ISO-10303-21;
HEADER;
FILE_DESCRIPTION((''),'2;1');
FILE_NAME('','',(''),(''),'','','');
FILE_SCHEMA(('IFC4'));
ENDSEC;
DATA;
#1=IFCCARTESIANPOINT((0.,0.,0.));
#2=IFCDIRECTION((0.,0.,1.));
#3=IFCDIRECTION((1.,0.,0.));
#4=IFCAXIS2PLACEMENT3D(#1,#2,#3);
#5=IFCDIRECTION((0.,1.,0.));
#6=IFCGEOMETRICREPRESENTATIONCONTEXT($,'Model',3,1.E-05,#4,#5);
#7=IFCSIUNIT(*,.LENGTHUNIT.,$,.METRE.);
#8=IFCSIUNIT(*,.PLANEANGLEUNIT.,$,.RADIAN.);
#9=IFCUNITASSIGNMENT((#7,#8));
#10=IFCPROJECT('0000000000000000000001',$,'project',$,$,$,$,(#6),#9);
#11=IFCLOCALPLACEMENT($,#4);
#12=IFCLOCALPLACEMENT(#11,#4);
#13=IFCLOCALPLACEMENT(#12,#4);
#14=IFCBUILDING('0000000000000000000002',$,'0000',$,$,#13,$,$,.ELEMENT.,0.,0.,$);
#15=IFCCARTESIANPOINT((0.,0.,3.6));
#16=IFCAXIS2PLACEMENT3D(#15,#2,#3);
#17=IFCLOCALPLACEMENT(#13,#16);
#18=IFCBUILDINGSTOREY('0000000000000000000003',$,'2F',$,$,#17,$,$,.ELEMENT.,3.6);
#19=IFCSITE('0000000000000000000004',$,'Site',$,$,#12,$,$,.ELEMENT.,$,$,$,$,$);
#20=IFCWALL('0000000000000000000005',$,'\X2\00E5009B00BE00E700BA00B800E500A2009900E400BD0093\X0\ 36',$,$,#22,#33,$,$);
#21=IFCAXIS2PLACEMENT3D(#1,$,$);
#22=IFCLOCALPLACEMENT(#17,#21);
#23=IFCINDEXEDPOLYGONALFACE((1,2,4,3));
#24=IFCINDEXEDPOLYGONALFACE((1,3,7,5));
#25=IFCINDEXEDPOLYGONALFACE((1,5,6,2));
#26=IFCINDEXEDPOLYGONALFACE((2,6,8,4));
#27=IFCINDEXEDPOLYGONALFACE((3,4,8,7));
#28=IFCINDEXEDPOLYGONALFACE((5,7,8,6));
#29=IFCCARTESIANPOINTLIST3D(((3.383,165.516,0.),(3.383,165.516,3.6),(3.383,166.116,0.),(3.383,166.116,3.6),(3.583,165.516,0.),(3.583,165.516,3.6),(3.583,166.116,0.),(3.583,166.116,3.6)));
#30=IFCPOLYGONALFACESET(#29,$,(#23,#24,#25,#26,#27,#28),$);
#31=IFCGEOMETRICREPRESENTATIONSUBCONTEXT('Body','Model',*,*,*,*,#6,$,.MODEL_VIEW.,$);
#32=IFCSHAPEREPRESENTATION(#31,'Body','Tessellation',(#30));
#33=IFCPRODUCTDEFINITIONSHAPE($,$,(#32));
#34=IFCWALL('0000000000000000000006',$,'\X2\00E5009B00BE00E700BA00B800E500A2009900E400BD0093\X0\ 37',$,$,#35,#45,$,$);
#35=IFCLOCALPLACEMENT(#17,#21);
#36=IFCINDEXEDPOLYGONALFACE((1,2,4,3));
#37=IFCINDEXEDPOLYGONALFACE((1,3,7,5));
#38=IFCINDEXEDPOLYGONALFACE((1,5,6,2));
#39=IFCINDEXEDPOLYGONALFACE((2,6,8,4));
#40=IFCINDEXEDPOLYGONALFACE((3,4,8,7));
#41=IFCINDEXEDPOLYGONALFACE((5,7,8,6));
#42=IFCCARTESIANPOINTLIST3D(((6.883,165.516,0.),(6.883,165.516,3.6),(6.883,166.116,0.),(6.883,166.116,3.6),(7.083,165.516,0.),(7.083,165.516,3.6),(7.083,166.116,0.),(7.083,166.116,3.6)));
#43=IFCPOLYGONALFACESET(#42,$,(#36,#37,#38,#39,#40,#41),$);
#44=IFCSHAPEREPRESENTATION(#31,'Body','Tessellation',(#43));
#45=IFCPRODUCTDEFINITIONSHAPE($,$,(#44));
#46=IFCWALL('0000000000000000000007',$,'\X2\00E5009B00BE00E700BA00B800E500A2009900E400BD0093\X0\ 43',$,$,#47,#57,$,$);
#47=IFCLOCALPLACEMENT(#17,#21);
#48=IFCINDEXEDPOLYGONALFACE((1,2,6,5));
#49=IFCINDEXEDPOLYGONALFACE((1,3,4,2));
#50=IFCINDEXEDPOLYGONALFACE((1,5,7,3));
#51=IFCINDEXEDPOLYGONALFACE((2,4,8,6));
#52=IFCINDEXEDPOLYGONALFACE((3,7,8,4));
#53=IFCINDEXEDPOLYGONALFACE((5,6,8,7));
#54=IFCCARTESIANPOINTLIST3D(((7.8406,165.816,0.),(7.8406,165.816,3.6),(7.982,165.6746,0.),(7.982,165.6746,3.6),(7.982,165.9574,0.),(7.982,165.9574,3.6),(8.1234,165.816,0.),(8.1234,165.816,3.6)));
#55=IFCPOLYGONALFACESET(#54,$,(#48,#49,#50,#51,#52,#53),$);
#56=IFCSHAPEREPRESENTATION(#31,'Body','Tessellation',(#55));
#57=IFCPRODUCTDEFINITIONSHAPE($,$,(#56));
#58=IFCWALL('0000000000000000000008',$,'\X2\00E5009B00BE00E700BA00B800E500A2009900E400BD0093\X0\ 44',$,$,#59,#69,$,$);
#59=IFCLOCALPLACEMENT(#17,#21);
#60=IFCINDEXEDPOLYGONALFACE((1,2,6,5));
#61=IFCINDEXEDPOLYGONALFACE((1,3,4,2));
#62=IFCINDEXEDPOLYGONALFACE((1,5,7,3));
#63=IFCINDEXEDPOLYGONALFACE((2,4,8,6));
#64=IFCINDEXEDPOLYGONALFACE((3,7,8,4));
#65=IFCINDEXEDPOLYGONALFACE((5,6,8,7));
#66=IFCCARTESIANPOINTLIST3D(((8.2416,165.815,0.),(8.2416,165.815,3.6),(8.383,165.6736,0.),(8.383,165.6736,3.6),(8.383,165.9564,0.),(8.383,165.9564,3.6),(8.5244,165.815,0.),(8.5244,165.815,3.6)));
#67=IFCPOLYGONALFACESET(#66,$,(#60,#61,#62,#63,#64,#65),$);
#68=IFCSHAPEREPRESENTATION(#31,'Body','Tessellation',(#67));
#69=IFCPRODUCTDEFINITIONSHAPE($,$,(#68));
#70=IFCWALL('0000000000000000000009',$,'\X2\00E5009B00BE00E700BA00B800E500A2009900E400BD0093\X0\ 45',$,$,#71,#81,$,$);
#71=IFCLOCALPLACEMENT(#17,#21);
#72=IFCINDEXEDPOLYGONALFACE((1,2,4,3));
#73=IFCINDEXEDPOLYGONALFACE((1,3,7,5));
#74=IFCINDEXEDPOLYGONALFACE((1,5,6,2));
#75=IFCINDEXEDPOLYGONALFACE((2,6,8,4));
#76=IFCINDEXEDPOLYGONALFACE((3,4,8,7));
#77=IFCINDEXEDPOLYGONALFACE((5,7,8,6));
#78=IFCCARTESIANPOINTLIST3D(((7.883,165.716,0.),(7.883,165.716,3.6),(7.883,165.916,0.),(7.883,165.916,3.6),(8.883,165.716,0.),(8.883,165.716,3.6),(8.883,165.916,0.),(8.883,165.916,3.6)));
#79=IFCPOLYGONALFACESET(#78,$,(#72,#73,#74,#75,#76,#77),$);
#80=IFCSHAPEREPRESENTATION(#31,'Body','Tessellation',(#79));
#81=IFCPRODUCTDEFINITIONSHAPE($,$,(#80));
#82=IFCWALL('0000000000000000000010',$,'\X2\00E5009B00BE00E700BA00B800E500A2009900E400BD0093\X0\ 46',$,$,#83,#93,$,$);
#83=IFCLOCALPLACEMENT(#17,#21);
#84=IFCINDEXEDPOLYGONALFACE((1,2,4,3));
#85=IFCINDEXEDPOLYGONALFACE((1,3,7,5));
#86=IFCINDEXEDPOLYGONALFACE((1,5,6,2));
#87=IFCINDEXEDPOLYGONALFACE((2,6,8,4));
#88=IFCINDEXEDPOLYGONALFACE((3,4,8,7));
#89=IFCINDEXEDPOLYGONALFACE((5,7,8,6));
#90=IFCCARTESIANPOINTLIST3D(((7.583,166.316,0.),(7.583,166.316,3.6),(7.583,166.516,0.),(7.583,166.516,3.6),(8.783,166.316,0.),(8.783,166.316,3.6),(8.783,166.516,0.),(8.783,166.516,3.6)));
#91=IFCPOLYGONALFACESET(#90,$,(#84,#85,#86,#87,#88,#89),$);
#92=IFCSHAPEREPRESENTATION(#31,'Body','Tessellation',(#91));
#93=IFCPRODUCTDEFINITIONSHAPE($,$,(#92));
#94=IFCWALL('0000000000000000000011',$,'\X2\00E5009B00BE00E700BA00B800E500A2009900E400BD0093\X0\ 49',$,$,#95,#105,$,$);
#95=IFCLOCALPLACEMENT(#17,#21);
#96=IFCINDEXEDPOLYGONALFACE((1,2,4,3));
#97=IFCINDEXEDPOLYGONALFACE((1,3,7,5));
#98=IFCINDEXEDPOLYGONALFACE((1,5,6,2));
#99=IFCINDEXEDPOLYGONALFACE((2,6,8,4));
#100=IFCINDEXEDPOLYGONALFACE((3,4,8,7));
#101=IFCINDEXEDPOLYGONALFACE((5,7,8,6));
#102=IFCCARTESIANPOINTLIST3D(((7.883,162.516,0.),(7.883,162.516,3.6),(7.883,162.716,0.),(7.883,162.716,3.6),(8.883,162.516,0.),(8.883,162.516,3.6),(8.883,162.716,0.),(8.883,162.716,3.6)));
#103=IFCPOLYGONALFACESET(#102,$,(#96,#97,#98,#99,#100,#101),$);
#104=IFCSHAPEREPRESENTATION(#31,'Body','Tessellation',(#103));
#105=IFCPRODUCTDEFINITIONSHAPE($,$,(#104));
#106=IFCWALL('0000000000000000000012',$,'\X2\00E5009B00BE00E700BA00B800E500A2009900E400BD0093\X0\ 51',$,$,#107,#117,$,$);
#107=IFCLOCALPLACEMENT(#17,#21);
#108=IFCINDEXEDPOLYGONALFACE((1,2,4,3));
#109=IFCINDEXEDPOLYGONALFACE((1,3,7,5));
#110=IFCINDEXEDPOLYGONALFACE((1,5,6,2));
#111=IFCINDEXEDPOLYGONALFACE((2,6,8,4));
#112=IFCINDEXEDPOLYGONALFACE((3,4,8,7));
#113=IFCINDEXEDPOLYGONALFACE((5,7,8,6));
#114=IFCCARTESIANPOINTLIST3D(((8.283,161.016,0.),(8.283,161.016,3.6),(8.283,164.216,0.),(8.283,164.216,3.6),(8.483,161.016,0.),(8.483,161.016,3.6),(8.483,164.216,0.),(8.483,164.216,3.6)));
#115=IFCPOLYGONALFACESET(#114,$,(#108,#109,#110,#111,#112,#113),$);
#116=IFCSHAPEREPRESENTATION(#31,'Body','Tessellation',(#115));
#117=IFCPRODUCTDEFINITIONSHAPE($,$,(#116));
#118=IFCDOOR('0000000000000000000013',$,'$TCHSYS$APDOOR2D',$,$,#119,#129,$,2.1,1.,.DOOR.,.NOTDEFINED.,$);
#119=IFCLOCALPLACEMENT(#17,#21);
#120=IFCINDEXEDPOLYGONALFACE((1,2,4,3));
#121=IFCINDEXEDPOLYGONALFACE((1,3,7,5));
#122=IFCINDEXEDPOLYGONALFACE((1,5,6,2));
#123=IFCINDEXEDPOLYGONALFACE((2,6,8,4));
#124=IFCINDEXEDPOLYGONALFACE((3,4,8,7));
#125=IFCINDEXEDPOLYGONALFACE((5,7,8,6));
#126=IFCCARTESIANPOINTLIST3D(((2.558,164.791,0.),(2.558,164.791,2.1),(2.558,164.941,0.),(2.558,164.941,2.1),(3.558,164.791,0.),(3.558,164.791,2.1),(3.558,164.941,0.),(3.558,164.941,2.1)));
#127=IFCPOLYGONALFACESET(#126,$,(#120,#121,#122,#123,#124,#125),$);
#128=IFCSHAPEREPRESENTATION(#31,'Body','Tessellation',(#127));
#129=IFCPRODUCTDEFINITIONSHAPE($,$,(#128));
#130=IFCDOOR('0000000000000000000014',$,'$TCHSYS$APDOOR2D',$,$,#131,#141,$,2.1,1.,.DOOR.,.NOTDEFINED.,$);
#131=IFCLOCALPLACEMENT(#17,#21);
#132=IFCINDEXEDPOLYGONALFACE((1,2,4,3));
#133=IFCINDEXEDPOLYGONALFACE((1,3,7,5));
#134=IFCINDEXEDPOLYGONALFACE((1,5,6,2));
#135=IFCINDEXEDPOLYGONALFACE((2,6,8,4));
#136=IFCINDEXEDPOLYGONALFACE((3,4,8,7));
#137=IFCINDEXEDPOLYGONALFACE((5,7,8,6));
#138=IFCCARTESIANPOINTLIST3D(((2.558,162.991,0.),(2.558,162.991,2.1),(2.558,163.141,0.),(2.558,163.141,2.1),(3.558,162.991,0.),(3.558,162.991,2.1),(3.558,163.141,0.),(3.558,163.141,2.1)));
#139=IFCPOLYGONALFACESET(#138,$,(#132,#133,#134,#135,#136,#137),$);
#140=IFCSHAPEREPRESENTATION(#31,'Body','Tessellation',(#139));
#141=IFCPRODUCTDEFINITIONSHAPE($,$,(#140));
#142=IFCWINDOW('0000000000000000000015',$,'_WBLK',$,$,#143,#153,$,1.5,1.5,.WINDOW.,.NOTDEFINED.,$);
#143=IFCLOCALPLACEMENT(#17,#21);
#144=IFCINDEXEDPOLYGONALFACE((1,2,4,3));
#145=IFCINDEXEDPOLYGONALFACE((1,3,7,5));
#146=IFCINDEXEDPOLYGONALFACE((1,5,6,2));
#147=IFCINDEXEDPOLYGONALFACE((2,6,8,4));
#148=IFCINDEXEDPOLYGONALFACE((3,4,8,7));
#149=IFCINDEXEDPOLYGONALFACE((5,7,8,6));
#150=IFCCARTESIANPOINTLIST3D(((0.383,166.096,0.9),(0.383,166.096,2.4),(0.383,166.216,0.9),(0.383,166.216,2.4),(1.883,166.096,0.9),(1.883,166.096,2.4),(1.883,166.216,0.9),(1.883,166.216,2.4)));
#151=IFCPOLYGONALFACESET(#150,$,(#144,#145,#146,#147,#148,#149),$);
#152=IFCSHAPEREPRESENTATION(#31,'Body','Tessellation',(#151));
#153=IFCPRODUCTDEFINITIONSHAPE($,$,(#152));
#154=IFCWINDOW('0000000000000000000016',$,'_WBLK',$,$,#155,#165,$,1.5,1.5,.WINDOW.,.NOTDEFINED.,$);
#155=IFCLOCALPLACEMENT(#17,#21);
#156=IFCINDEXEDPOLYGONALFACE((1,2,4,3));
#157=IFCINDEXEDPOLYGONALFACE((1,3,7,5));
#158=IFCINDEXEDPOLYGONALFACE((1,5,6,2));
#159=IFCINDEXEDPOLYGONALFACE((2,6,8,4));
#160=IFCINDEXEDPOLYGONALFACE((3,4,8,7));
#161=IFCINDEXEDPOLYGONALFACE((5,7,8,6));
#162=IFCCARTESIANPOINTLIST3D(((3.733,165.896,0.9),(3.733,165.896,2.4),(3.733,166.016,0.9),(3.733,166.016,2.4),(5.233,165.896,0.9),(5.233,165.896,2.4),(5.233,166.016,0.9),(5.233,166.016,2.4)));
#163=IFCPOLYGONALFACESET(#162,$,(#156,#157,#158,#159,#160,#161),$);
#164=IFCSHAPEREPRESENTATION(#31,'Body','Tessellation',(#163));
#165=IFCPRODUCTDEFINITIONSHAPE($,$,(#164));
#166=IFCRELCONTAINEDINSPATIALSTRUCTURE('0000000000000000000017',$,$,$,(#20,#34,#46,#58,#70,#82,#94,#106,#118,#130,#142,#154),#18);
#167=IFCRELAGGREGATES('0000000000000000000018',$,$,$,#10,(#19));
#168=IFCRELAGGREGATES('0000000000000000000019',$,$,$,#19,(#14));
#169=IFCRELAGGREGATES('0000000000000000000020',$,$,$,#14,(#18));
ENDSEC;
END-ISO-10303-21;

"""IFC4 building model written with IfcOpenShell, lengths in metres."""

from ifc_helpers import new_model, si_unit, direction, frame, frame_2d, origin_with_axes, place, context, subcontext, project, spatial, rectangle, extrude, element, save


model = new_model("IFC4")

# Units and contexts
model_context = context("Model", 3, precision=1e-05, world=origin_with_axes(), true_north=direction((0.0, 1.0, 0.0)))
body_context = subcontext(model_context, "Body", "Model", "MODEL_VIEW")
ifc_project = project(units=[si_unit("LENGTHUNIT", "METRE"), si_unit("PLANEANGLEUNIT", "RADIAN")], contexts=[model_context])

# Site, building, storey
placement = place(None, origin_with_axes())
site_placement = place(placement, origin_with_axes())
site = spatial("IfcSite", under=ifc_project, at=site_placement, Name="Site", CompositionType="ELEMENT")
building_placement = place(site_placement, origin_with_axes())
building = spatial("IfcBuilding", under=site, at=building_placement, Name="0000", CompositionType="ELEMENT", ElevationOfRefHeight=0.0, ElevationOfTerrain=0.0)
storey_placement = place(building_placement, frame((0.0, 0.0, 3.6), z_axis=(0.0, 0.0, 1.0), x_axis=(1.0, 0.0, 0.0)))
storey = spatial("IfcBuildingStorey", under=building, at=storey_placement, Name="2F", CompositionType="ELEMENT", Elevation=3.6)

# Walls
for number, where, z_axis, x_axis, name in (
    (1, (3.483, 165.816, 0.0), (0.0, 0.0, 1.0), (0.0, 1.0, 0.0), "å\u009b¾çº¸å¢\u0099ä½\u0093 36"),
    (2, (6.983, 165.816, 0.0), (0.0, 0.0, 1.0), (0.0, 1.0, 0.0), "å\u009b¾çº¸å¢\u0099ä½\u0093 37"),
):
    element("IfcWall", number, at=place(storey_placement, frame(where, z_axis=z_axis, x_axis=x_axis)), inside=storey, Name=name, context=body_context, shape_type="SweptSolid", body=[
        extrude(rectangle(XDim=0.6, YDim=0.2, at=frame_2d((0.0, 0.0), x_axis=(1.0, 0.0, 0.0))), frame((0.0, 0.0, 0.0), z_axis=(0.0, 0.0, 1.0)), (0.0, 0.0, 1.0), 3.6),
    ])
for number, where, z_axis, x_axis, name in (
    (3, (7.982, 165.816, 0.0), (0.0, 0.0, 1.0), (0.707107, -0.707107, 0.0), "å\u009b¾çº¸å¢\u0099ä½\u0093 43"),
    (4, (8.383, 165.815, 0.0), (0.0, 0.0, 1.0), (0.707107, 0.707107, 0.0), "å\u009b¾çº¸å¢\u0099ä½\u0093 44"),
):
    element("IfcWall", number, at=place(storey_placement, frame(where, z_axis=z_axis, x_axis=x_axis)), inside=storey, Name=name, context=body_context, shape_type="SweptSolid", body=[
        extrude(rectangle(XDim=0.2, YDim=0.2, at=frame_2d((0.0, 0.0), x_axis=(1.0, 0.0, 0.0))), frame((0.0, 0.0, 0.0), z_axis=(0.0, 0.0, 1.0)), (0.0, 0.0, 1.0), 3.6),
    ])
wall_1_placement = place(storey_placement, frame((8.383, 165.816, 0.0), z_axis=(0.0, 0.0, 1.0), x_axis=(1.0, 0.0, 0.0)))
element("IfcWall", 5, at=wall_1_placement, inside=storey, Name="å\u009b¾çº¸å¢\u0099ä½\u0093 45", context=body_context, shape_type="SweptSolid", body=[
    extrude(rectangle(XDim=1.0, YDim=0.2, at=frame_2d((0.0, 0.0), x_axis=(1.0, 0.0, 0.0))), frame((0.0, 0.0, 0.0), z_axis=(0.0, 0.0, 1.0)), (0.0, 0.0, 1.0), 3.6),
])
wall_2_placement = place(storey_placement, frame((8.183, 166.416, 0.0), z_axis=(0.0, 0.0, 1.0), x_axis=(1.0, 0.0, 0.0)))
element("IfcWall", 6, at=wall_2_placement, inside=storey, Name="å\u009b¾çº¸å¢\u0099ä½\u0093 46", context=body_context, shape_type="SweptSolid", body=[
    extrude(rectangle(XDim=1.2, YDim=0.2, at=frame_2d((0.0, 0.0), x_axis=(1.0, 0.0, 0.0))), frame((0.0, 0.0, 0.0), z_axis=(0.0, 0.0, 1.0)), (0.0, 0.0, 1.0), 3.6),
])
wall_3_placement = place(storey_placement, frame((8.383, 162.616, 0.0), z_axis=(0.0, 0.0, 1.0), x_axis=(1.0, 0.0, 0.0)))
element("IfcWall", 7, at=wall_3_placement, inside=storey, Name="å\u009b¾çº¸å¢\u0099ä½\u0093 49", context=body_context, shape_type="SweptSolid", body=[
    extrude(rectangle(XDim=1.0, YDim=0.2, at=frame_2d((0.0, 0.0), x_axis=(1.0, 0.0, 0.0))), frame((0.0, 0.0, 0.0), z_axis=(0.0, 0.0, 1.0)), (0.0, 0.0, 1.0), 3.6),
])
wall_4_placement = place(storey_placement, frame((8.383, 162.616, 0.0), z_axis=(0.0, 0.0, 1.0), x_axis=(0.0, 1.0, 0.0)))
element("IfcWall", 8, at=wall_4_placement, inside=storey, Name="å\u009b¾çº¸å¢\u0099ä½\u0093 51", context=body_context, shape_type="SweptSolid", body=[
    extrude(rectangle(XDim=3.2, YDim=0.2, at=frame_2d((0.0, 0.0), x_axis=(1.0, 0.0, 0.0))), frame((0.0, 0.0, 0.0), z_axis=(0.0, 0.0, 1.0)), (0.0, 0.0, 1.0), 3.6),
])

# Doors
for number, where, z_axis, x_axis, name in (
    (9, (3.058, 164.866, 0.0), (0.0, 0.0, 1.0), (1.0, 0.0, 0.0), "$TCHSYS$APDOOR2D"),
    (10, (3.058, 163.066, 0.0), (0.0, 0.0, 1.0), (1.0, 0.0, 0.0), "$TCHSYS$APDOOR2D"),
):
    element("IfcDoor", number, at=place(storey_placement, frame(where, z_axis=z_axis, x_axis=x_axis)), inside=storey, Name=name, OperationType="NOTDEFINED", OverallHeight=2.1, OverallWidth=1.0, PredefinedType="DOOR", context=body_context, shape_type="SweptSolid", body=[
        extrude(rectangle(XDim=1.0, YDim=0.15, at=frame_2d((0.0, 0.0), x_axis=(1.0, 0.0, 0.0))), frame((0.0, 0.0, 0.0), z_axis=(0.0, 0.0, 1.0)), (0.0, 0.0, 1.0), 2.1),
    ])

# Windows
for number, where, z_axis, x_axis, name in (
    (11, (1.133, 166.156, 0.9), (0.0, 0.0, 1.0), (1.0, 0.0, 0.0), "_WBLK"),
    (12, (4.483, 165.956, 0.9), (0.0, 0.0, 1.0), (1.0, 0.0, 0.0), "_WBLK"),
):
    element("IfcWindow", number, at=place(storey_placement, frame(where, z_axis=z_axis, x_axis=x_axis)), inside=storey, Name=name, OverallHeight=1.5, OverallWidth=1.5, PartitioningType="NOTDEFINED", PredefinedType="WINDOW", context=body_context, shape_type="SweptSolid", body=[
        extrude(rectangle(XDim=1.5, YDim=0.12, at=frame_2d((0.0, 0.0), x_axis=(1.0, 0.0, 0.0))), frame((0.0, 0.0, 0.0), z_axis=(0.0, 0.0, 1.0)), (0.0, 0.0, 1.0), 1.5),
    ])

save(model, "model.ifc")
